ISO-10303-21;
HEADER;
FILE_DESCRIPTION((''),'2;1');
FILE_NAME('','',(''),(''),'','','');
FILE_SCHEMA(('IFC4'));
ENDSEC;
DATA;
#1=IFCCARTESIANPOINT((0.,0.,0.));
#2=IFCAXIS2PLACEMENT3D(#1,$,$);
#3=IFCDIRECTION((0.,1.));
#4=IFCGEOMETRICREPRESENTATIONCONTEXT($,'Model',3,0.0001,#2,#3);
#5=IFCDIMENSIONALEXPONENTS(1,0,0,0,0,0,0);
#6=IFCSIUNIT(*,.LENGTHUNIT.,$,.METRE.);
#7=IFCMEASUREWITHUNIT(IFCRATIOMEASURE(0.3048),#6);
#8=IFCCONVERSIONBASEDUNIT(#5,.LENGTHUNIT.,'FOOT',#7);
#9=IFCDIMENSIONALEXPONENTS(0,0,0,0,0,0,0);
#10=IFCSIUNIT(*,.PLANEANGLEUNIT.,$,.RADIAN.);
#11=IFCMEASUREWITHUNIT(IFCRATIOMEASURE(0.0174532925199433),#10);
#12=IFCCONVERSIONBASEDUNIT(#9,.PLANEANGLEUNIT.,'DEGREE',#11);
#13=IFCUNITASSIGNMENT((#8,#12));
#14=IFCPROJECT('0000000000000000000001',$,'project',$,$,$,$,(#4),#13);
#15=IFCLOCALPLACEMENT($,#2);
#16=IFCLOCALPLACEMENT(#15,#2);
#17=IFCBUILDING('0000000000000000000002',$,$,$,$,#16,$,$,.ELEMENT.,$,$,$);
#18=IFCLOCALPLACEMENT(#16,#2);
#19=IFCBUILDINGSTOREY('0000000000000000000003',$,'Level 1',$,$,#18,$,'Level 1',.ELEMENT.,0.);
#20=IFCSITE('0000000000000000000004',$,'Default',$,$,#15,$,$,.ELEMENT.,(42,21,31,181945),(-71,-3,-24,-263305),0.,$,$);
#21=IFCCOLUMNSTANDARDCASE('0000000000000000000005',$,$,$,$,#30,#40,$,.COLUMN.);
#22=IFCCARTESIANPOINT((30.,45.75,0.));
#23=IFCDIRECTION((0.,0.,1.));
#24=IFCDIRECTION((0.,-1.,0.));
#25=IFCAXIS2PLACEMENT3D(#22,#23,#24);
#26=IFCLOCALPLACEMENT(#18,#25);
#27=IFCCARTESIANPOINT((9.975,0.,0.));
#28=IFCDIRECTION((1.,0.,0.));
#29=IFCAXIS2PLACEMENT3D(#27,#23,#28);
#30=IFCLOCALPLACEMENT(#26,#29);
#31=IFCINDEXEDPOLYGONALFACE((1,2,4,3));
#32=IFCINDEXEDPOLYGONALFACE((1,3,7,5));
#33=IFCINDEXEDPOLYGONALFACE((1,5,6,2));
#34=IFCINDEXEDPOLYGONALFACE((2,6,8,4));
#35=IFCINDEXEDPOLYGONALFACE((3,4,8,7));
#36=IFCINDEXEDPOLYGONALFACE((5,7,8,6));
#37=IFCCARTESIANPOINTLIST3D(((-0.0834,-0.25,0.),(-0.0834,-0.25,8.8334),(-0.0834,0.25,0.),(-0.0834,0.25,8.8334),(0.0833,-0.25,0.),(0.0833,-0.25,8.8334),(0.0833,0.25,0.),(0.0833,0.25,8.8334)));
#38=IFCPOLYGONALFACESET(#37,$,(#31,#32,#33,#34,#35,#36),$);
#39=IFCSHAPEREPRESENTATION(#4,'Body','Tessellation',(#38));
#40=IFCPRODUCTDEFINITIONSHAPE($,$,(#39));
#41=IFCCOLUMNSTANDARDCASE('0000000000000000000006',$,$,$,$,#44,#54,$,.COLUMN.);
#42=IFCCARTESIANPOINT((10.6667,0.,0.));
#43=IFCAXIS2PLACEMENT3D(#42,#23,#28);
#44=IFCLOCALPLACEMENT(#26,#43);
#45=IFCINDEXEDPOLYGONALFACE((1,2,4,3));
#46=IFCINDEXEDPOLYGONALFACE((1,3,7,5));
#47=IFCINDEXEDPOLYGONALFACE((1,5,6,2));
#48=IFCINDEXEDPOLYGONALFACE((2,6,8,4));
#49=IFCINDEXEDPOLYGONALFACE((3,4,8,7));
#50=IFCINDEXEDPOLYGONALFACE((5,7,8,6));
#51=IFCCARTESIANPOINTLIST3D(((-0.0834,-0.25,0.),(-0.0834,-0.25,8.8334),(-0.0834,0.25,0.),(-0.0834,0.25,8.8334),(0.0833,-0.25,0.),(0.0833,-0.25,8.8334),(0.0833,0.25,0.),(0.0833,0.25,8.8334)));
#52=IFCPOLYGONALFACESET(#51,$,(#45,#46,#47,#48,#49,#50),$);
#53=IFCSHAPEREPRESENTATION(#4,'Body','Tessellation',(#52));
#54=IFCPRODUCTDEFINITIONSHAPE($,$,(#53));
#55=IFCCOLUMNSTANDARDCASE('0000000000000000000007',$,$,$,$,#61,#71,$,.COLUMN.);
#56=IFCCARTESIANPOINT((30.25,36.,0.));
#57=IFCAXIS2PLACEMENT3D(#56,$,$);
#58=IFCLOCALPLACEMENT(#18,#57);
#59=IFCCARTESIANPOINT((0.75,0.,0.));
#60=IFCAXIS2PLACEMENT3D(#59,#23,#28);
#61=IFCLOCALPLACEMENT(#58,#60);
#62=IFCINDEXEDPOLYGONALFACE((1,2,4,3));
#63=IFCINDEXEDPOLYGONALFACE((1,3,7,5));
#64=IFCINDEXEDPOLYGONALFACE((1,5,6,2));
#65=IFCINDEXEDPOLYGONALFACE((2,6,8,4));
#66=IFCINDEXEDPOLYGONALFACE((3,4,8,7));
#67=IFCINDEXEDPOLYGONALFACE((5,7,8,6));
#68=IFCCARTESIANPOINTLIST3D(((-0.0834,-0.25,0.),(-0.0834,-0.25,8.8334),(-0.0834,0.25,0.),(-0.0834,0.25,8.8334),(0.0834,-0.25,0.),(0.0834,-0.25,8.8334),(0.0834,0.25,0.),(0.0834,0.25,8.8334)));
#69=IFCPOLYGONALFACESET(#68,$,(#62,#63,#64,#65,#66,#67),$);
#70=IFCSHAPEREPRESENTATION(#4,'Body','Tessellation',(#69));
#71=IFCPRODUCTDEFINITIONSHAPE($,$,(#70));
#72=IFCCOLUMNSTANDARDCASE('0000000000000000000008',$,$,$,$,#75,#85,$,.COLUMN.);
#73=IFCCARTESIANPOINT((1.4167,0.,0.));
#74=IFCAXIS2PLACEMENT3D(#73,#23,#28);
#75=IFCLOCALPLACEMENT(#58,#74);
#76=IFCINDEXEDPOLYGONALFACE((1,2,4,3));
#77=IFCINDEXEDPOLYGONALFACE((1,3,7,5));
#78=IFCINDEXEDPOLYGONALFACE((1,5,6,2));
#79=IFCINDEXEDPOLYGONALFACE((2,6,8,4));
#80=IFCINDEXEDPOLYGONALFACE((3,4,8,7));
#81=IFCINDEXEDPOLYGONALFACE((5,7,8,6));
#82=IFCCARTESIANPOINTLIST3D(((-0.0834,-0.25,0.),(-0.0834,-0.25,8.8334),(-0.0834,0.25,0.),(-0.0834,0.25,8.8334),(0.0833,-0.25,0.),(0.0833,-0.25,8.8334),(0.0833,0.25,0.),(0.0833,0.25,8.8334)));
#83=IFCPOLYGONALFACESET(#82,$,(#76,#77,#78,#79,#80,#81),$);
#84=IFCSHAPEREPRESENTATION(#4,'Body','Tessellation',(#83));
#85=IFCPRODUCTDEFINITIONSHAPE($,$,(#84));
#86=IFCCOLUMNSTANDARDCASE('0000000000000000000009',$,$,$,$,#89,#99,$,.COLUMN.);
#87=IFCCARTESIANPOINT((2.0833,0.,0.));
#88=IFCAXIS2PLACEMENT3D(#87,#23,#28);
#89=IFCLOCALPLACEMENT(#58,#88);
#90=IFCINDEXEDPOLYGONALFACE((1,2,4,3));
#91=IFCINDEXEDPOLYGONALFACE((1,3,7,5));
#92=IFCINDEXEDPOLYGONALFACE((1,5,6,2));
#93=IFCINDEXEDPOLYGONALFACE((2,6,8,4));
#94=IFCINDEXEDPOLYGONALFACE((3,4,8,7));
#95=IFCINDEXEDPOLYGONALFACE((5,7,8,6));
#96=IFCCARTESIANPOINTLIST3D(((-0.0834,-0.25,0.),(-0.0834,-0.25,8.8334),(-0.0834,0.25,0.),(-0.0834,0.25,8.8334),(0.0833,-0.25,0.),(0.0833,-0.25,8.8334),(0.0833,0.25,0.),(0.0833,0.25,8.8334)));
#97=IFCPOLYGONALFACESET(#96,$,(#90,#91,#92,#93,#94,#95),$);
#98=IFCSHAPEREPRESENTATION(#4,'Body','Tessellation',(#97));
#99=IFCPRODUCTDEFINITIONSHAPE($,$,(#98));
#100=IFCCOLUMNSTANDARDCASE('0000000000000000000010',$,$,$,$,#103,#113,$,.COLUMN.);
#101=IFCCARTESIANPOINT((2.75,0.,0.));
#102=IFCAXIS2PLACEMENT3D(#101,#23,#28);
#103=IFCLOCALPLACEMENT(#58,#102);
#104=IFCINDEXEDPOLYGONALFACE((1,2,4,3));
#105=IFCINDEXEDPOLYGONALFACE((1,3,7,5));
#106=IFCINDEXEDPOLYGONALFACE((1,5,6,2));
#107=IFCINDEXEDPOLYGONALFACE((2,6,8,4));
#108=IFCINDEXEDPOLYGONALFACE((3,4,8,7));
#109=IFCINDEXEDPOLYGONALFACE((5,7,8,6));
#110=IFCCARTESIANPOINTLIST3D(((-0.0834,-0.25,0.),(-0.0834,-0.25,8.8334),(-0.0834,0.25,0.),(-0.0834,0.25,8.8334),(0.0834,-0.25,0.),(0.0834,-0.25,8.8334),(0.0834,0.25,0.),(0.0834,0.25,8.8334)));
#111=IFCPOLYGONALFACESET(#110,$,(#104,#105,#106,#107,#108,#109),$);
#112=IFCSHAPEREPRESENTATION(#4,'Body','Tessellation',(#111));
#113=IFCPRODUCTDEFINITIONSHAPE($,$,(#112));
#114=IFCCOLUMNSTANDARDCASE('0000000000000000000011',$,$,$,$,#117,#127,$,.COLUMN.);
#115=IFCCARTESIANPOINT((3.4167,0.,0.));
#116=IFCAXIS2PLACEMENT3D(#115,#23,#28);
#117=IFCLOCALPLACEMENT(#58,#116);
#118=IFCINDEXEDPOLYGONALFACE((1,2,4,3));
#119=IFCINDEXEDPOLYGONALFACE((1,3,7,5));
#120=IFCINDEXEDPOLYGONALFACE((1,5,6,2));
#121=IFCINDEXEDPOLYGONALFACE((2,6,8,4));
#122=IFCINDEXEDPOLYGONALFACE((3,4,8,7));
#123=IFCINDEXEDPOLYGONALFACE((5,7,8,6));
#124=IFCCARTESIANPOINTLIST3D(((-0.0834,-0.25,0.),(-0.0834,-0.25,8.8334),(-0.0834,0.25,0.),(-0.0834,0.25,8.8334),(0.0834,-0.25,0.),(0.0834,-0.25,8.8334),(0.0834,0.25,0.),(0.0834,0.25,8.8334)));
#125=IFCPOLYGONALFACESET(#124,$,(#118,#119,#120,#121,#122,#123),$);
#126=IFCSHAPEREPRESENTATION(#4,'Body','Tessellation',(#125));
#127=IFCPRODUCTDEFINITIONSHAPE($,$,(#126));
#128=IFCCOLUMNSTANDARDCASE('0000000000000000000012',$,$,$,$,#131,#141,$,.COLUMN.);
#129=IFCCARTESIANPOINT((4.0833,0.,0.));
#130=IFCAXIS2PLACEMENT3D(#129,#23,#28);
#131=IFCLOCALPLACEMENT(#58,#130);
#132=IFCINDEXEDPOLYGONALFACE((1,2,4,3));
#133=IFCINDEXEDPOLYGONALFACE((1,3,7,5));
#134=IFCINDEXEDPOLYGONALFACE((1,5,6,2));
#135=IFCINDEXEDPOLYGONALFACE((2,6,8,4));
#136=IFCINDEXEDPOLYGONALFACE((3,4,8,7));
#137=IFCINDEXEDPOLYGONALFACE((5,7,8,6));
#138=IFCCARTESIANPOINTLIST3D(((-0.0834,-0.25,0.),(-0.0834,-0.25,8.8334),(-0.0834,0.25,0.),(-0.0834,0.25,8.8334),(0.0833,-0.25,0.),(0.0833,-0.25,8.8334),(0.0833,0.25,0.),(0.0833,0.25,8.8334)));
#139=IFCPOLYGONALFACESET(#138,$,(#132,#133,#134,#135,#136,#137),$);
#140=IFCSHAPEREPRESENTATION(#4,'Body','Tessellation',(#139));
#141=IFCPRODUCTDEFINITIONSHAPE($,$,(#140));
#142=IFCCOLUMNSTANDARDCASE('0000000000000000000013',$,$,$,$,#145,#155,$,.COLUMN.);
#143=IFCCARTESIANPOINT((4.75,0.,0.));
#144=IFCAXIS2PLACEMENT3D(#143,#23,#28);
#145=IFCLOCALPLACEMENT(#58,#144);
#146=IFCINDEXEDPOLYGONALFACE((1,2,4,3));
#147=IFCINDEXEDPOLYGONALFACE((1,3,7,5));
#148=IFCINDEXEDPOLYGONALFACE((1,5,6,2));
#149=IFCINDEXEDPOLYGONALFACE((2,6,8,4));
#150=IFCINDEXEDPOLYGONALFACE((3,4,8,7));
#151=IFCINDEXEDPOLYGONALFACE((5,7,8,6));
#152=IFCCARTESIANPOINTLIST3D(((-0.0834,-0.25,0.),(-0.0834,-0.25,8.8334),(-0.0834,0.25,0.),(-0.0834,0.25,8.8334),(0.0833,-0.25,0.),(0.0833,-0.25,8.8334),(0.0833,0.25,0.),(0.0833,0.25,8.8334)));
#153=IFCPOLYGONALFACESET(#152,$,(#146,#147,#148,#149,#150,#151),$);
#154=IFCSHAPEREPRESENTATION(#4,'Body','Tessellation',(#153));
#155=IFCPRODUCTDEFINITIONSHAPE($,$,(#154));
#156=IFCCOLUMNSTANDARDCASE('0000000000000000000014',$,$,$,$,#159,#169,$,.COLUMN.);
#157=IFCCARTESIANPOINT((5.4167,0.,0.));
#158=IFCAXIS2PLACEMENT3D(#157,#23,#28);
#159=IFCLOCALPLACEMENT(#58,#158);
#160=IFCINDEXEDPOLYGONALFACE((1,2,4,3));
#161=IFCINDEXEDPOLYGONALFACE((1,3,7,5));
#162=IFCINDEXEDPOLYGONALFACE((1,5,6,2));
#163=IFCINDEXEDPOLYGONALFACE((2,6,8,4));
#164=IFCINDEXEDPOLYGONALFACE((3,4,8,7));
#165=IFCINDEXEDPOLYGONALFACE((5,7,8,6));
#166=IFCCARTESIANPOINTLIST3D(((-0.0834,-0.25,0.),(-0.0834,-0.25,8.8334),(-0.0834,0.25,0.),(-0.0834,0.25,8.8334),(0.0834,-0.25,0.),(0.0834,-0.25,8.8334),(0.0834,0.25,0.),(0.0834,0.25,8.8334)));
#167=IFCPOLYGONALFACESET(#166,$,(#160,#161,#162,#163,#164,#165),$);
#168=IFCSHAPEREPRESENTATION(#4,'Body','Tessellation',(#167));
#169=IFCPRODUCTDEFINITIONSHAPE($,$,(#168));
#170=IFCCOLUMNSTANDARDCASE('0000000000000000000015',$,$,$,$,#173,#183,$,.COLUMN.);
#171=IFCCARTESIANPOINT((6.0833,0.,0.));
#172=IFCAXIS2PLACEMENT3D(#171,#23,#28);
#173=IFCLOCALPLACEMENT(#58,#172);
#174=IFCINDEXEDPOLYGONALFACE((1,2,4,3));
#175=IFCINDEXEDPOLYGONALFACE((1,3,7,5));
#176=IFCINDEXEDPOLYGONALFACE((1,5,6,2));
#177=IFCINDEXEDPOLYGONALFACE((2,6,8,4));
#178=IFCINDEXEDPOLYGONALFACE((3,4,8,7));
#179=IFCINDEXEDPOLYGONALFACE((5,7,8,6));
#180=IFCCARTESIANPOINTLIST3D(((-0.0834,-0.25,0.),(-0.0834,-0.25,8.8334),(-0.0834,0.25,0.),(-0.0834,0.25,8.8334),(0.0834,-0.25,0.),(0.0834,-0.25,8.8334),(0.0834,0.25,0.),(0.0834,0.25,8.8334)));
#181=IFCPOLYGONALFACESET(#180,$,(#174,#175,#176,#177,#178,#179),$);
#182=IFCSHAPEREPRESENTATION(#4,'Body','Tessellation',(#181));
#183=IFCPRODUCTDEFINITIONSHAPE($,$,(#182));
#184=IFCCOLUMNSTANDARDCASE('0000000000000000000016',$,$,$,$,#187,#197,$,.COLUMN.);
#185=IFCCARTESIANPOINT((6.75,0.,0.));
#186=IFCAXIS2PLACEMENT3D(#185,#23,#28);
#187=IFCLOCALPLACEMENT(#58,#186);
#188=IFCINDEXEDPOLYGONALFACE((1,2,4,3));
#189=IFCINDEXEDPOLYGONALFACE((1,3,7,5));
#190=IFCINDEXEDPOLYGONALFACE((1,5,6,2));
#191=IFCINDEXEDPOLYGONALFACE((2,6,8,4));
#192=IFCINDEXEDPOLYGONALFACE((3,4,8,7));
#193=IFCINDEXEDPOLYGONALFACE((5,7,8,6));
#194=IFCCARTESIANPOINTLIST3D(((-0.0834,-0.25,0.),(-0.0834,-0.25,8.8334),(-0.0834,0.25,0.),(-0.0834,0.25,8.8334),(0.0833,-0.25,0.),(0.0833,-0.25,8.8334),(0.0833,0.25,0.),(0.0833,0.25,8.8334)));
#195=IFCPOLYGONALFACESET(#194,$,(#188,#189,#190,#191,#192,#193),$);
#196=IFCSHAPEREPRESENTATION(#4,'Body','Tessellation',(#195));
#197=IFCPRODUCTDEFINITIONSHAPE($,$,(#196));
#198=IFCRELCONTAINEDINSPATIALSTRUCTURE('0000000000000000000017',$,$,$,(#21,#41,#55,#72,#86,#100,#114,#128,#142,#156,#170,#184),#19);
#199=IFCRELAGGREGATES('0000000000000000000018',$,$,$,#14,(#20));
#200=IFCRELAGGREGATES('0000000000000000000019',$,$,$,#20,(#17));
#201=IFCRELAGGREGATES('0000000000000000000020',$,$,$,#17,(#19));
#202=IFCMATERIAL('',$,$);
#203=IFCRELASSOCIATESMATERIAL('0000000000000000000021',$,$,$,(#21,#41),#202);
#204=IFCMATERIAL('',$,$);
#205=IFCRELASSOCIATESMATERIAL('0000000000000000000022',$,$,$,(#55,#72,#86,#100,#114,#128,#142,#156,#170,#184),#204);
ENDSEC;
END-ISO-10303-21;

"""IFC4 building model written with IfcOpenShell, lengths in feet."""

from ifc_helpers import new_model, entity, si_unit, converted_unit, direction, frame, origin, place, context, project, spatial, rectangle, extrude, material, element, save


model = new_model("IFC4")

# Units and contexts
model_context = context("Model", 3, precision=0.0001, world=origin(), true_north=direction((0.0, 1.0)))
ifc_project = project(units=[converted_unit("LENGTHUNIT", "FOOT", entity("IfcRatioMeasure", 0.3048), si_unit("LENGTHUNIT", "METRE"), dimensions=[1, 0, 0, 0, 0, 0, 0]), converted_unit("PLANEANGLEUNIT", "DEGREE", entity("IfcRatioMeasure", 0.0174532925199433), si_unit("PLANEANGLEUNIT", "RADIAN"), dimensions=[0, 0, 0, 0, 0, 0, 0])], contexts=[model_context])

# Site, building, storey
site_placement = place(None, origin())
site = spatial("IfcSite", under=ifc_project, at=site_placement, Name="Default", CompositionType="ELEMENT", RefLatitude=(42, 21, 31, 181945), RefLongitude=(-71, -3, -24, -263305), RefElevation=0.0)
building_placement = place(site_placement, origin())
building = spatial("IfcBuilding", under=site, at=building_placement, CompositionType="ELEMENT")
storey_placement = place(building_placement, origin())
storey = spatial("IfcBuildingStorey", under=building, at=storey_placement, Name="Level 1", LongName="Level 1", CompositionType="ELEMENT", Elevation=0.0)

# Columns
ifc_material_1 = material(Name="")
placement_1 = place(storey_placement, frame((30.0, 45.75, 0.0), z_axis=(0.0, 0.0, 1.0), x_axis=(0.0, -1.0, 0.0)))
for number, where, z_axis, x_axis in (
    (1, (9.975, 0.0, 0.0), (0.0, 0.0, 1.0), (1.0, 0.0, 0.0)),
    (2, (10.6667, 0.0, 0.0), (0.0, 0.0, 1.0), (1.0, 0.0, 0.0)),
):
    element("IfcColumnStandardCase", number, at=place(placement_1, frame(where, z_axis=z_axis, x_axis=x_axis)), inside=storey, material=ifc_material_1, PredefinedType="COLUMN", context=model_context, shape_type="SweptSolid", body=[
        extrude(rectangle(XDim=0.1667, YDim=0.5), origin(), (0.0, 0.0, 1.0), 8.8334),
    ])
ifc_material_2 = material(Name="")
placement_2 = place(storey_placement, frame((30.25, 36.0, 0.0)))
for number, where, z_axis, x_axis in (
    (3, (0.75, 0.0, 0.0), (0.0, 0.0, 1.0), (1.0, 0.0, 0.0)),
    (4, (1.4167, 0.0, 0.0), (0.0, 0.0, 1.0), (1.0, 0.0, 0.0)),
    (5, (2.0833, 0.0, 0.0), (0.0, 0.0, 1.0), (1.0, 0.0, 0.0)),
    (6, (2.75, 0.0, 0.0), (0.0, 0.0, 1.0), (1.0, 0.0, 0.0)),
    (7, (3.4167, 0.0, 0.0), (0.0, 0.0, 1.0), (1.0, 0.0, 0.0)),
    (8, (4.0833, 0.0, 0.0), (0.0, 0.0, 1.0), (1.0, 0.0, 0.0)),
    (9, (4.75, 0.0, 0.0), (0.0, 0.0, 1.0), (1.0, 0.0, 0.0)),
    (10, (5.4167, 0.0, 0.0), (0.0, 0.0, 1.0), (1.0, 0.0, 0.0)),
    (11, (6.0833, 0.0, 0.0), (0.0, 0.0, 1.0), (1.0, 0.0, 0.0)),
    (12, (6.75, 0.0, 0.0), (0.0, 0.0, 1.0), (1.0, 0.0, 0.0)),
):
    element("IfcColumnStandardCase", number, at=place(placement_2, frame(where, z_axis=z_axis, x_axis=x_axis)), inside=storey, material=ifc_material_2, PredefinedType="COLUMN", context=model_context, shape_type="SweptSolid", body=[
        extrude(rectangle(XDim=0.1667, YDim=0.5), origin(), (0.0, 0.0, 1.0), 8.8334),
    ])

save(model, "model.ifc")
